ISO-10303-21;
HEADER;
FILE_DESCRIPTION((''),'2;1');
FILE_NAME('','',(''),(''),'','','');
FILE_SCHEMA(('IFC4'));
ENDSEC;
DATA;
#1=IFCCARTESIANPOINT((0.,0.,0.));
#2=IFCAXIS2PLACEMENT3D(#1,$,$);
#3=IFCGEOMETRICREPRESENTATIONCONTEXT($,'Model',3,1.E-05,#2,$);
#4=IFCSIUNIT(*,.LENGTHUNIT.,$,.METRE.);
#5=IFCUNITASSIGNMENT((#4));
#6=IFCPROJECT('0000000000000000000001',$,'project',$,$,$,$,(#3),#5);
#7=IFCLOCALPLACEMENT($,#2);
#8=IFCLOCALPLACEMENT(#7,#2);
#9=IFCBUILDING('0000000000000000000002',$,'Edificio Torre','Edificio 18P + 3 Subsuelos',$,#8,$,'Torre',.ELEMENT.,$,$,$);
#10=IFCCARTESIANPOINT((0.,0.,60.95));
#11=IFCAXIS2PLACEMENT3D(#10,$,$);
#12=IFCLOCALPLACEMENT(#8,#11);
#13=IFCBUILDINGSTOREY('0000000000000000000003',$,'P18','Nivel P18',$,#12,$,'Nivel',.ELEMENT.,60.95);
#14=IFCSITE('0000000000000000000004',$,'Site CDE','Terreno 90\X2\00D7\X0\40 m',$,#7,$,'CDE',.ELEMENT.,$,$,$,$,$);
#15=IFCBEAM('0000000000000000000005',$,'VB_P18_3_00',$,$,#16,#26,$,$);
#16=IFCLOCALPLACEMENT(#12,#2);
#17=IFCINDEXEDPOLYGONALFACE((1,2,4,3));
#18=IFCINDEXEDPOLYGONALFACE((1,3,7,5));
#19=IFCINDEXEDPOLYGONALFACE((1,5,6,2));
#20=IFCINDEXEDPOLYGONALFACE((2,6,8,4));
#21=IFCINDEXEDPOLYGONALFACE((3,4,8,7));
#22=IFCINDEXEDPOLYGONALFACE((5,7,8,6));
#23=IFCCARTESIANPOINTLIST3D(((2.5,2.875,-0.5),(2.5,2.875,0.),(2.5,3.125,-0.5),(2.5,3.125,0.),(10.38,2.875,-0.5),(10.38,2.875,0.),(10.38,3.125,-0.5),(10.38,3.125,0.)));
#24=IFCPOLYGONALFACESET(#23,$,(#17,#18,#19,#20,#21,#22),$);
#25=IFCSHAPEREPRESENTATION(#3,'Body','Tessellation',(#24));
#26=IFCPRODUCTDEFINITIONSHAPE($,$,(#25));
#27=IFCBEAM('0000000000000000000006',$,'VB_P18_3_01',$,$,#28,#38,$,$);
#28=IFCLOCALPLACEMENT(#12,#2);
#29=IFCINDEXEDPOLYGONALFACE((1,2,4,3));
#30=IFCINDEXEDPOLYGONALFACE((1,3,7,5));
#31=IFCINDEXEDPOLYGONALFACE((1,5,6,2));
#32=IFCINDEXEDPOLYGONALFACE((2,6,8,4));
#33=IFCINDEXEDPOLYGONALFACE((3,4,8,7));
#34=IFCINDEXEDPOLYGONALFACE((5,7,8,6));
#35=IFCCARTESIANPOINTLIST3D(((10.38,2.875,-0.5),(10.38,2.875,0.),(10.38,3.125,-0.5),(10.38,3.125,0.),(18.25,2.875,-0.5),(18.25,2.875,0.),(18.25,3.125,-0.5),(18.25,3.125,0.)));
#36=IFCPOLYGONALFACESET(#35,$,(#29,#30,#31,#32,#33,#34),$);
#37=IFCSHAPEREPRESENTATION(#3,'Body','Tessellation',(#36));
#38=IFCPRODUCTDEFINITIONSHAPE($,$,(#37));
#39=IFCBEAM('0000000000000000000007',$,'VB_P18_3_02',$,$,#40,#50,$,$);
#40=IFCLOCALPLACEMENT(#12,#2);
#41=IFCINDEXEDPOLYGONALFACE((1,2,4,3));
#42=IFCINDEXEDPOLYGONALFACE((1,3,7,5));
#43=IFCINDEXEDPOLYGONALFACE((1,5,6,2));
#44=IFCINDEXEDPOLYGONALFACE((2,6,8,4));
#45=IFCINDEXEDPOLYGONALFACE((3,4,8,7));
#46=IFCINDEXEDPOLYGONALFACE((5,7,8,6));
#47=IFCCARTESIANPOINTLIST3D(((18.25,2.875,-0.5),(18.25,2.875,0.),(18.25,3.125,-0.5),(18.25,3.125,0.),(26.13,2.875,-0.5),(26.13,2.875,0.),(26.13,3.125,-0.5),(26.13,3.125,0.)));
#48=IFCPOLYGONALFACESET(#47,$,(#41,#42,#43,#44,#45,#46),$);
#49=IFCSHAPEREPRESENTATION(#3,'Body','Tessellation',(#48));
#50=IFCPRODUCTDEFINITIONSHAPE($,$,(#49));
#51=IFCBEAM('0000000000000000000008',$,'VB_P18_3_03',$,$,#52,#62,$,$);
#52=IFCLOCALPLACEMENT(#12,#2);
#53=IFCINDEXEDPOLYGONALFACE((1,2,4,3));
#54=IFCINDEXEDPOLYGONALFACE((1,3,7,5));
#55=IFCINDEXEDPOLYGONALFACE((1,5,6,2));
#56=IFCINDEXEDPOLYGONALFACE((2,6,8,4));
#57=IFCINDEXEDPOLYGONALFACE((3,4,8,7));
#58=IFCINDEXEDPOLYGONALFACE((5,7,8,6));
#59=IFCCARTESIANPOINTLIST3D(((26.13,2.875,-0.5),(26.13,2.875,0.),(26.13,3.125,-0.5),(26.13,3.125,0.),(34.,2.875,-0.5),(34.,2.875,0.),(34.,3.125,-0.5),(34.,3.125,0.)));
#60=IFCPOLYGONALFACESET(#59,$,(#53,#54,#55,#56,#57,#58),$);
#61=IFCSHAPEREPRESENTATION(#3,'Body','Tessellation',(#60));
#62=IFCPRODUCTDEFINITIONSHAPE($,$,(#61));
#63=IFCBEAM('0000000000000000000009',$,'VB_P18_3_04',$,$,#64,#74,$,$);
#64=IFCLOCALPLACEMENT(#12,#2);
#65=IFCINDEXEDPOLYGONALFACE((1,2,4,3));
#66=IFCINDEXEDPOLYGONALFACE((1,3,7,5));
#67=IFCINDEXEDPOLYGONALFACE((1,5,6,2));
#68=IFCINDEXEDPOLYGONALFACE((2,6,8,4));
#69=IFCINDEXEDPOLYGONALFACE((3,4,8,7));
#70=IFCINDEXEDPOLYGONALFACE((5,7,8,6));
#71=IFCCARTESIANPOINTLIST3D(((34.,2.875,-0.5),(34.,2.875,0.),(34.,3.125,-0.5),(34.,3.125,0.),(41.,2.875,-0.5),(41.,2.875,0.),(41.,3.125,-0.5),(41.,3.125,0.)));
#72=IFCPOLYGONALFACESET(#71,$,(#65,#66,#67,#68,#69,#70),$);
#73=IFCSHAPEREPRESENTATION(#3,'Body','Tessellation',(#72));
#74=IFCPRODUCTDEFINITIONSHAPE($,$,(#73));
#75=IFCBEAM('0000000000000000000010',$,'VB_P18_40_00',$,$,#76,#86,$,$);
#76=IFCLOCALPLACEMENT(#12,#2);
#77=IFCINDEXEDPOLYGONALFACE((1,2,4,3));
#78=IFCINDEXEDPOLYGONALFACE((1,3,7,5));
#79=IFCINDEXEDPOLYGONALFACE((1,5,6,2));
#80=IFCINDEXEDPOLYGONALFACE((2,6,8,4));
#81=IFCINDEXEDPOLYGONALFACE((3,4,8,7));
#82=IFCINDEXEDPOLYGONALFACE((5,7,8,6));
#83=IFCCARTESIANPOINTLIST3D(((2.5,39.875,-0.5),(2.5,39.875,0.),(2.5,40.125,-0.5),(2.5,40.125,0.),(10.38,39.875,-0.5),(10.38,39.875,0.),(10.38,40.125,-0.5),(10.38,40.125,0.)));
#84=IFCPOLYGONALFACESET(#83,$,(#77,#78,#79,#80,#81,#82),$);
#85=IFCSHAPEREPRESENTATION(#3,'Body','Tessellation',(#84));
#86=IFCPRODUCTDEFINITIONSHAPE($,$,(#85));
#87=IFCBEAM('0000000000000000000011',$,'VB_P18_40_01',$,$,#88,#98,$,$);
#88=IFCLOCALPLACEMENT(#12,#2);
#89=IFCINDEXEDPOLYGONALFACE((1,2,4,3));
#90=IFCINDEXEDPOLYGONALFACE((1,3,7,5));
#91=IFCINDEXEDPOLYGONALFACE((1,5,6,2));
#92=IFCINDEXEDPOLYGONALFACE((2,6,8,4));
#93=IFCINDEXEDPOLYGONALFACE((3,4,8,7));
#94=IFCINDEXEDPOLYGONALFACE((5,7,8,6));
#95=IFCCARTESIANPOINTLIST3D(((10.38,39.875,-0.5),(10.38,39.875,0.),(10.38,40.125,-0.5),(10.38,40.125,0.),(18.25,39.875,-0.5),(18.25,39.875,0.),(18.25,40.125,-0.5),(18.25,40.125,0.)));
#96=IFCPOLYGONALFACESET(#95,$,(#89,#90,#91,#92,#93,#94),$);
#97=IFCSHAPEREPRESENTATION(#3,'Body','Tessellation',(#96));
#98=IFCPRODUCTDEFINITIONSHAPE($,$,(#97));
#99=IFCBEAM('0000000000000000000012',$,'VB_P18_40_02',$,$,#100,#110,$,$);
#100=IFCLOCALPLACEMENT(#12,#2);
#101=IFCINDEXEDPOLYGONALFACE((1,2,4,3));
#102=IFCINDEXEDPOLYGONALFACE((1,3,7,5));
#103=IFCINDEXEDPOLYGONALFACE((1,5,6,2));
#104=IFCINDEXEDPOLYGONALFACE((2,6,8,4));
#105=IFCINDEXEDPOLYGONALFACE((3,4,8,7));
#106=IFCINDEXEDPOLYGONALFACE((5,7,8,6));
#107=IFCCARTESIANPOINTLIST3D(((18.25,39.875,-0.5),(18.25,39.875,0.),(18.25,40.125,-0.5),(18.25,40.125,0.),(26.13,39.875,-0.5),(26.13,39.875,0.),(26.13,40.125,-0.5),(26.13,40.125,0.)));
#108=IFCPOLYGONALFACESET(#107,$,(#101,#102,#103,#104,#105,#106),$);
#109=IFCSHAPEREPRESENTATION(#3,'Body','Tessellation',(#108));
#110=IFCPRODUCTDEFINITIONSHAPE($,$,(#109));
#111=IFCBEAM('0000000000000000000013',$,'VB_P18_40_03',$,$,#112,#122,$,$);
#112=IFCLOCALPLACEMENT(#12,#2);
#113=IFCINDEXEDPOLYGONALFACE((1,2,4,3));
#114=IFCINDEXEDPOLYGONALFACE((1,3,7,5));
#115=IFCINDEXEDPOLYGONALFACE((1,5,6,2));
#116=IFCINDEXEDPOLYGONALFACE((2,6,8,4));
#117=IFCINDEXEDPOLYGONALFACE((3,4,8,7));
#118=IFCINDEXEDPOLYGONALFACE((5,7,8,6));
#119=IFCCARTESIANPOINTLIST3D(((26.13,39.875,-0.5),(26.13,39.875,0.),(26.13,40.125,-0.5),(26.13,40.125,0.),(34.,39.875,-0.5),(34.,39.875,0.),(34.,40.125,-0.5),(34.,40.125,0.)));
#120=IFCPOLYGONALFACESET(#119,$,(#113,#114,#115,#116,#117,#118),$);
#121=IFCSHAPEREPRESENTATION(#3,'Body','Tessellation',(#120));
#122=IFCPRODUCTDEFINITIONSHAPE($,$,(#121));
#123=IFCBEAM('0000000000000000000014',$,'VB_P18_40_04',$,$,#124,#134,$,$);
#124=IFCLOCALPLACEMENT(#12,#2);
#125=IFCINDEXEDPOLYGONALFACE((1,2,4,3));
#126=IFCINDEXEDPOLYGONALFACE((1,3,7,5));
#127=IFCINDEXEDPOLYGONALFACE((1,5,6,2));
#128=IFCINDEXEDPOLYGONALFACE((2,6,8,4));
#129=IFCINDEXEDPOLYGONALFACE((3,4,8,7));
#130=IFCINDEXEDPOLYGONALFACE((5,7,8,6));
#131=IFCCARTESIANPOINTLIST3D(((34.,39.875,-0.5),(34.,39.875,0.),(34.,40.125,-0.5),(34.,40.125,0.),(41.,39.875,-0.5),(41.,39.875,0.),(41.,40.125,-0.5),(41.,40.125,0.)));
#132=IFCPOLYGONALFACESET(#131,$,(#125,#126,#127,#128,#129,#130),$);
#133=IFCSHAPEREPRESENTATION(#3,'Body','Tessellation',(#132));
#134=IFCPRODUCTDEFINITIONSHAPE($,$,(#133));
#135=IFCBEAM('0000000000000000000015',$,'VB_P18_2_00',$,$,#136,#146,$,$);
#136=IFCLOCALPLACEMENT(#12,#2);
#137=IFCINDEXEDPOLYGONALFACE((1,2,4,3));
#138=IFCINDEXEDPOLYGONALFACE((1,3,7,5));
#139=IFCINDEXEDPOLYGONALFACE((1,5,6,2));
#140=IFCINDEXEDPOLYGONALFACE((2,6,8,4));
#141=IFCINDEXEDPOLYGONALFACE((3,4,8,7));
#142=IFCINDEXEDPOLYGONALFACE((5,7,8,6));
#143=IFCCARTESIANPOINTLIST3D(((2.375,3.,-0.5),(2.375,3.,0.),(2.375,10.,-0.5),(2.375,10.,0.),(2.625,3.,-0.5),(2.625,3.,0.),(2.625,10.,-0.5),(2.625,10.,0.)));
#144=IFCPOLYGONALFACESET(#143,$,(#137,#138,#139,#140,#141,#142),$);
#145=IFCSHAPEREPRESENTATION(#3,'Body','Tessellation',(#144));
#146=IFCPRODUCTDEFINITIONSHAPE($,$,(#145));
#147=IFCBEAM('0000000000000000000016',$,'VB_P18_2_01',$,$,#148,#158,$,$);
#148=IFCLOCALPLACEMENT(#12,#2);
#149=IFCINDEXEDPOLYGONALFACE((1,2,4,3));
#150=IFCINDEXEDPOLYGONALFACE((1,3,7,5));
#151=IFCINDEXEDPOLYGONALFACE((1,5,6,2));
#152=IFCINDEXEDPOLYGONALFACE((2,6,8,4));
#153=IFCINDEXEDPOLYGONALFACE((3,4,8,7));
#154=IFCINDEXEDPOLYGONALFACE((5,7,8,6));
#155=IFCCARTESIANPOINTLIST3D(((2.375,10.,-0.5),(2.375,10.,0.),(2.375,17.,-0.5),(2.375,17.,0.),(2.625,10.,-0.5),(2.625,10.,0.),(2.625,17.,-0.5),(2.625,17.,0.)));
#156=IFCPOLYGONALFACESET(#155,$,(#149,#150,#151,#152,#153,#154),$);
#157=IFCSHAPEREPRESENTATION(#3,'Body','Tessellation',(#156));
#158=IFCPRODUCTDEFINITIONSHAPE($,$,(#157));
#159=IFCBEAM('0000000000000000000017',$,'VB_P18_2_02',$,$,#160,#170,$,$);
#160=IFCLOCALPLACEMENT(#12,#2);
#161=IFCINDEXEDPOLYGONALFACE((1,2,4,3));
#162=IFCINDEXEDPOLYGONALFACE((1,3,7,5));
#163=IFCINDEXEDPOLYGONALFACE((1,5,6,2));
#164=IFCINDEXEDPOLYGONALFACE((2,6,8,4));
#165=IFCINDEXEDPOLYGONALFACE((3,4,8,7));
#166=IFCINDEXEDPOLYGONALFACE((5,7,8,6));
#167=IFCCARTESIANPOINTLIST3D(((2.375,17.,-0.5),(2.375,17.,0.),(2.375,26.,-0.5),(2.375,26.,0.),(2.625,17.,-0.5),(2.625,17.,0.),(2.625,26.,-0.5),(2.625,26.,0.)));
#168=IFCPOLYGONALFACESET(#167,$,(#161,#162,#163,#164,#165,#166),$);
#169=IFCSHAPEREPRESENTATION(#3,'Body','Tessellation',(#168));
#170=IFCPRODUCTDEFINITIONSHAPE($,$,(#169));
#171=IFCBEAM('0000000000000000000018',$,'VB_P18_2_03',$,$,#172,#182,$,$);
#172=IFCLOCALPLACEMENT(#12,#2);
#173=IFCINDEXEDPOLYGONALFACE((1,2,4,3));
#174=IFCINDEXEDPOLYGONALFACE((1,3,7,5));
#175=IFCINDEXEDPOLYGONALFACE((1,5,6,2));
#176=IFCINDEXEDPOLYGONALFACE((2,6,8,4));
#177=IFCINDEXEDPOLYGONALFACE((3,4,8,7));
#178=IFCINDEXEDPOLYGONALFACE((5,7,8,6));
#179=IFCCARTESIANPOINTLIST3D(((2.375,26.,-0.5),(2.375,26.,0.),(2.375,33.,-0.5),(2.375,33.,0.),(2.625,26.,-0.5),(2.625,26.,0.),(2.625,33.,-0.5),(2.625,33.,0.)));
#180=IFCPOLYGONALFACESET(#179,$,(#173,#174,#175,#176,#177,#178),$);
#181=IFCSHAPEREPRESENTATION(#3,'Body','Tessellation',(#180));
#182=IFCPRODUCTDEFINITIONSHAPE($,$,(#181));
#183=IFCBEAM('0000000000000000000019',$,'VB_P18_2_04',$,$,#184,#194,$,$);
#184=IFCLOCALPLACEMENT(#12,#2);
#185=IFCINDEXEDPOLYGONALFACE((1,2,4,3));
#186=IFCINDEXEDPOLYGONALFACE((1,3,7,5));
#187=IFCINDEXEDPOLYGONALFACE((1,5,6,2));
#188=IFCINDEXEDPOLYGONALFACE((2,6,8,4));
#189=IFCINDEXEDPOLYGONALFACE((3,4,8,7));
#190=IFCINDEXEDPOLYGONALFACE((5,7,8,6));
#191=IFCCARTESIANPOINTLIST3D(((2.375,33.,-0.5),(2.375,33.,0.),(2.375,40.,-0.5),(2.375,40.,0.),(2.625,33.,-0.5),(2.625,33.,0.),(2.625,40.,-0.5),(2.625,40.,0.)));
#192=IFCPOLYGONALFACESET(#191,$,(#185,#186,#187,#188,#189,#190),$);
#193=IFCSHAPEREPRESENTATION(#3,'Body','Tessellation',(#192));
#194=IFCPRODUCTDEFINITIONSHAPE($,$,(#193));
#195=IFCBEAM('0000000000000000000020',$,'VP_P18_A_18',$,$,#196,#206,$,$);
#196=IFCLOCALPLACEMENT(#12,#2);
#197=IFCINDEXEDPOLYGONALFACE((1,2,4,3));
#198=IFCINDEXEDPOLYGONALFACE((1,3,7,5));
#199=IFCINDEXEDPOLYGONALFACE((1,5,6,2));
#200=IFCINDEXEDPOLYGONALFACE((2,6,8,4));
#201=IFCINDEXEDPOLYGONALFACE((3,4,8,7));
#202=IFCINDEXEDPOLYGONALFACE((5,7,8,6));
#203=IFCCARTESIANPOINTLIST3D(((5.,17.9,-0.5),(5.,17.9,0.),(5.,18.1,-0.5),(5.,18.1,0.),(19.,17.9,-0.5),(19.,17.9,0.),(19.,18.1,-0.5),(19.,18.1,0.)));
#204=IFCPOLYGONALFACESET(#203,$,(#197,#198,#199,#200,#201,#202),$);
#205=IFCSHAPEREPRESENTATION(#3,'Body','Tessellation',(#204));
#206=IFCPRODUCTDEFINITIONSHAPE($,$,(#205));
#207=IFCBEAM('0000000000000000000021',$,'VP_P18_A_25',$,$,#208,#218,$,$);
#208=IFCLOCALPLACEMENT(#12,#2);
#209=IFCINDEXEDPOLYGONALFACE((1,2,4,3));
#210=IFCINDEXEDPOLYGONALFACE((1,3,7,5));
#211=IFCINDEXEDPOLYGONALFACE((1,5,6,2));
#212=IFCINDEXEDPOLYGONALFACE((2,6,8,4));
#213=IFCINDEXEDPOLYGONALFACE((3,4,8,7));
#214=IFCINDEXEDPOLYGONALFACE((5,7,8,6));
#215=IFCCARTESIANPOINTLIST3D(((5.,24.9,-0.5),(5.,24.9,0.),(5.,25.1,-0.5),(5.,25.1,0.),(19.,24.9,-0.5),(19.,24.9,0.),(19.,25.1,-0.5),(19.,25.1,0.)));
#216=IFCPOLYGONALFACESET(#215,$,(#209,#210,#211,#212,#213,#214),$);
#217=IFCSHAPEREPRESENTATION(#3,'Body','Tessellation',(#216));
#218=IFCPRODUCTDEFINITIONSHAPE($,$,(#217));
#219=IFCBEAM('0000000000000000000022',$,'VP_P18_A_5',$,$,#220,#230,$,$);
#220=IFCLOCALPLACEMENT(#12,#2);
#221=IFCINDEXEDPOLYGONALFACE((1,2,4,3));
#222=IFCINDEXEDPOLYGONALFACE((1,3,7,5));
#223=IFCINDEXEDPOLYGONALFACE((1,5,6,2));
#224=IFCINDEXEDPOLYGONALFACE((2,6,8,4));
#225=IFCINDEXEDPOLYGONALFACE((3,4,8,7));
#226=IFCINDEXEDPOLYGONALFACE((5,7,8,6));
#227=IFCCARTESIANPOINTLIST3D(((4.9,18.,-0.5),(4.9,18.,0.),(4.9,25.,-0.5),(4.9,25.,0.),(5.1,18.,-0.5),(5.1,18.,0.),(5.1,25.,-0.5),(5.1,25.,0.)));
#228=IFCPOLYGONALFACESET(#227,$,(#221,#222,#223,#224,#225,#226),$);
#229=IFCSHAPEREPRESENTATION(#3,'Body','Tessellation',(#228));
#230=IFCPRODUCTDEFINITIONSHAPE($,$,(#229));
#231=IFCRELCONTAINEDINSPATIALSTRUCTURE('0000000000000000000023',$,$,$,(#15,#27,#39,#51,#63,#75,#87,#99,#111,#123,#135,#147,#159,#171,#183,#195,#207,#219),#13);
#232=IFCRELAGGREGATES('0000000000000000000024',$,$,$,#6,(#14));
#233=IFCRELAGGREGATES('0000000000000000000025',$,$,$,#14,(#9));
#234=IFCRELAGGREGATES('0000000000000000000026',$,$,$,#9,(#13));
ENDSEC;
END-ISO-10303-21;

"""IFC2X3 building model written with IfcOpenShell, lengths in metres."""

from ifc_helpers import new_model, si_unit, frame, origin, origin_2d, place, context, project, spatial, rectangle, extrude, element, save


model = new_model("IFC2X3")

# Units and contexts
model_context = context("Model", 3, precision=1e-05, world=origin())
ifc_project = project(units=[si_unit("LENGTHUNIT", "METRE")], contexts=[model_context])

# Site, building, storey
site_placement = place(None, origin())
site = spatial("IfcSite", under=ifc_project, at=site_placement, Name="Site CDE", Description="Terreno 90×40 m", LongName="CDE", CompositionType="ELEMENT")
building_placement = place(site_placement, origin())
building = spatial("IfcBuilding", under=site, at=building_placement, Name="Edificio Torre", Description="Edificio 18P + 3 Subsuelos", LongName="Torre", CompositionType="ELEMENT")
storey_placement = place(building_placement, frame((0.0, 0.0, 60.95)))
storey = spatial("IfcBuildingStorey", under=building, at=storey_placement, Name="P18", Description="Nivel P18", LongName="Nivel", CompositionType="ELEMENT", Elevation=60.95)

# Beams
beam_1_placement = place(storey_placement, frame((6.44, 3.0, -0.5)))
element("IfcBeam", 1, at=beam_1_placement, inside=storey, Name="VB_P18_3_00", context=model_context, shape_type="SweptSolid", body=[
    extrude(rectangle(XDim=7.88, YDim=0.25, at=origin_2d()), origin(), (0.0, 0.0, 1.0), 0.5),
])
beam_2_placement = place(storey_placement, frame((14.315, 3.0, -0.5)))
element("IfcBeam", 2, at=beam_2_placement, inside=storey, Name="VB_P18_3_01", context=model_context, shape_type="SweptSolid", body=[
    extrude(rectangle(XDim=7.87, YDim=0.25, at=origin_2d()), origin(), (0.0, 0.0, 1.0), 0.5),
])
beam_3_placement = place(storey_placement, frame((22.19, 3.0, -0.5)))
element("IfcBeam", 3, at=beam_3_placement, inside=storey, Name="VB_P18_3_02", context=model_context, shape_type="SweptSolid", body=[
    extrude(rectangle(XDim=7.88, YDim=0.25, at=origin_2d()), origin(), (0.0, 0.0, 1.0), 0.5),
])
beam_4_placement = place(storey_placement, frame((30.065, 3.0, -0.5)))
element("IfcBeam", 4, at=beam_4_placement, inside=storey, Name="VB_P18_3_03", context=model_context, shape_type="SweptSolid", body=[
    extrude(rectangle(XDim=7.87, YDim=0.25, at=origin_2d()), origin(), (0.0, 0.0, 1.0), 0.5),
])
beam_5_placement = place(storey_placement, frame((37.5, 3.0, -0.5)))
element("IfcBeam", 5, at=beam_5_placement, inside=storey, Name="VB_P18_3_04", context=model_context, shape_type="SweptSolid", body=[
    extrude(rectangle(XDim=7.0, YDim=0.25, at=origin_2d()), origin(), (0.0, 0.0, 1.0), 0.5),
])
beam_6_placement = place(storey_placement, frame((6.44, 40.0, -0.5)))
element("IfcBeam", 6, at=beam_6_placement, inside=storey, Name="VB_P18_40_00", context=model_context, shape_type="SweptSolid", body=[
    extrude(rectangle(XDim=7.88, YDim=0.25, at=origin_2d()), origin(), (0.0, 0.0, 1.0), 0.5),
])
beam_7_placement = place(storey_placement, frame((14.315, 40.0, -0.5)))
element("IfcBeam", 7, at=beam_7_placement, inside=storey, Name="VB_P18_40_01", context=model_context, shape_type="SweptSolid", body=[
    extrude(rectangle(XDim=7.87, YDim=0.25, at=origin_2d()), origin(), (0.0, 0.0, 1.0), 0.5),
])
beam_8_placement = place(storey_placement, frame((22.19, 40.0, -0.5)))
element("IfcBeam", 8, at=beam_8_placement, inside=storey, Name="VB_P18_40_02", context=model_context, shape_type="SweptSolid", body=[
    extrude(rectangle(XDim=7.88, YDim=0.25, at=origin_2d()), origin(), (0.0, 0.0, 1.0), 0.5),
])
beam_9_placement = place(storey_placement, frame((30.065, 40.0, -0.5)))
element("IfcBeam", 9, at=beam_9_placement, inside=storey, Name="VB_P18_40_03", context=model_context, shape_type="SweptSolid", body=[
    extrude(rectangle(XDim=7.87, YDim=0.25, at=origin_2d()), origin(), (0.0, 0.0, 1.0), 0.5),
])
beam_10_placement = place(storey_placement, frame((37.5, 40.0, -0.5)))
element("IfcBeam", 10, at=beam_10_placement, inside=storey, Name="VB_P18_40_04", context=model_context, shape_type="SweptSolid", body=[
    extrude(rectangle(XDim=7.0, YDim=0.25, at=origin_2d()), origin(), (0.0, 0.0, 1.0), 0.5),
])
for number, where, name in (
    (11, (2.5, 6.5, -0.5), "VB_P18_2_00"),
    (12, (2.5, 13.5, -0.5), "VB_P18_2_01"),
):
    element("IfcBeam", number, at=place(storey_placement, frame(where)), inside=storey, Name=name, context=model_context, shape_type="SweptSolid", body=[
        extrude(rectangle(XDim=0.25, YDim=7.0, at=origin_2d()), origin(), (0.0, 0.0, 1.0), 0.5),
    ])
beam_11_placement = place(storey_placement, frame((2.5, 21.5, -0.5)))
element("IfcBeam", 13, at=beam_11_placement, inside=storey, Name="VB_P18_2_02", context=model_context, shape_type="SweptSolid", body=[
    extrude(rectangle(XDim=0.25, YDim=9.0, at=origin_2d()), origin(), (0.0, 0.0, 1.0), 0.5),
])
for number, where, name in (
    (14, (2.5, 29.5, -0.5), "VB_P18_2_03"),
    (15, (2.5, 36.5, -0.5), "VB_P18_2_04"),
):
    element("IfcBeam", number, at=place(storey_placement, frame(where)), inside=storey, Name=name, context=model_context, shape_type="SweptSolid", body=[
        extrude(rectangle(XDim=0.25, YDim=7.0, at=origin_2d()), origin(), (0.0, 0.0, 1.0), 0.5),
    ])
for number, where, name in (
    (16, (12.0, 18.0, -0.5), "VP_P18_A_18"),
    (17, (12.0, 25.0, -0.5), "VP_P18_A_25"),
):
    element("IfcBeam", number, at=place(storey_placement, frame(where)), inside=storey, Name=name, context=model_context, shape_type="SweptSolid", body=[
        extrude(rectangle(XDim=14.0, YDim=0.2, at=origin_2d()), origin(), (0.0, 0.0, 1.0), 0.5),
    ])
beam_12_placement = place(storey_placement, frame((5.0, 21.5, -0.5)))
element("IfcBeam", 18, at=beam_12_placement, inside=storey, Name="VP_P18_A_5", context=model_context, shape_type="SweptSolid", body=[
    extrude(rectangle(XDim=0.2, YDim=7.0, at=origin_2d()), origin(), (0.0, 0.0, 1.0), 0.5),
])

save(model, "model.ifc")
